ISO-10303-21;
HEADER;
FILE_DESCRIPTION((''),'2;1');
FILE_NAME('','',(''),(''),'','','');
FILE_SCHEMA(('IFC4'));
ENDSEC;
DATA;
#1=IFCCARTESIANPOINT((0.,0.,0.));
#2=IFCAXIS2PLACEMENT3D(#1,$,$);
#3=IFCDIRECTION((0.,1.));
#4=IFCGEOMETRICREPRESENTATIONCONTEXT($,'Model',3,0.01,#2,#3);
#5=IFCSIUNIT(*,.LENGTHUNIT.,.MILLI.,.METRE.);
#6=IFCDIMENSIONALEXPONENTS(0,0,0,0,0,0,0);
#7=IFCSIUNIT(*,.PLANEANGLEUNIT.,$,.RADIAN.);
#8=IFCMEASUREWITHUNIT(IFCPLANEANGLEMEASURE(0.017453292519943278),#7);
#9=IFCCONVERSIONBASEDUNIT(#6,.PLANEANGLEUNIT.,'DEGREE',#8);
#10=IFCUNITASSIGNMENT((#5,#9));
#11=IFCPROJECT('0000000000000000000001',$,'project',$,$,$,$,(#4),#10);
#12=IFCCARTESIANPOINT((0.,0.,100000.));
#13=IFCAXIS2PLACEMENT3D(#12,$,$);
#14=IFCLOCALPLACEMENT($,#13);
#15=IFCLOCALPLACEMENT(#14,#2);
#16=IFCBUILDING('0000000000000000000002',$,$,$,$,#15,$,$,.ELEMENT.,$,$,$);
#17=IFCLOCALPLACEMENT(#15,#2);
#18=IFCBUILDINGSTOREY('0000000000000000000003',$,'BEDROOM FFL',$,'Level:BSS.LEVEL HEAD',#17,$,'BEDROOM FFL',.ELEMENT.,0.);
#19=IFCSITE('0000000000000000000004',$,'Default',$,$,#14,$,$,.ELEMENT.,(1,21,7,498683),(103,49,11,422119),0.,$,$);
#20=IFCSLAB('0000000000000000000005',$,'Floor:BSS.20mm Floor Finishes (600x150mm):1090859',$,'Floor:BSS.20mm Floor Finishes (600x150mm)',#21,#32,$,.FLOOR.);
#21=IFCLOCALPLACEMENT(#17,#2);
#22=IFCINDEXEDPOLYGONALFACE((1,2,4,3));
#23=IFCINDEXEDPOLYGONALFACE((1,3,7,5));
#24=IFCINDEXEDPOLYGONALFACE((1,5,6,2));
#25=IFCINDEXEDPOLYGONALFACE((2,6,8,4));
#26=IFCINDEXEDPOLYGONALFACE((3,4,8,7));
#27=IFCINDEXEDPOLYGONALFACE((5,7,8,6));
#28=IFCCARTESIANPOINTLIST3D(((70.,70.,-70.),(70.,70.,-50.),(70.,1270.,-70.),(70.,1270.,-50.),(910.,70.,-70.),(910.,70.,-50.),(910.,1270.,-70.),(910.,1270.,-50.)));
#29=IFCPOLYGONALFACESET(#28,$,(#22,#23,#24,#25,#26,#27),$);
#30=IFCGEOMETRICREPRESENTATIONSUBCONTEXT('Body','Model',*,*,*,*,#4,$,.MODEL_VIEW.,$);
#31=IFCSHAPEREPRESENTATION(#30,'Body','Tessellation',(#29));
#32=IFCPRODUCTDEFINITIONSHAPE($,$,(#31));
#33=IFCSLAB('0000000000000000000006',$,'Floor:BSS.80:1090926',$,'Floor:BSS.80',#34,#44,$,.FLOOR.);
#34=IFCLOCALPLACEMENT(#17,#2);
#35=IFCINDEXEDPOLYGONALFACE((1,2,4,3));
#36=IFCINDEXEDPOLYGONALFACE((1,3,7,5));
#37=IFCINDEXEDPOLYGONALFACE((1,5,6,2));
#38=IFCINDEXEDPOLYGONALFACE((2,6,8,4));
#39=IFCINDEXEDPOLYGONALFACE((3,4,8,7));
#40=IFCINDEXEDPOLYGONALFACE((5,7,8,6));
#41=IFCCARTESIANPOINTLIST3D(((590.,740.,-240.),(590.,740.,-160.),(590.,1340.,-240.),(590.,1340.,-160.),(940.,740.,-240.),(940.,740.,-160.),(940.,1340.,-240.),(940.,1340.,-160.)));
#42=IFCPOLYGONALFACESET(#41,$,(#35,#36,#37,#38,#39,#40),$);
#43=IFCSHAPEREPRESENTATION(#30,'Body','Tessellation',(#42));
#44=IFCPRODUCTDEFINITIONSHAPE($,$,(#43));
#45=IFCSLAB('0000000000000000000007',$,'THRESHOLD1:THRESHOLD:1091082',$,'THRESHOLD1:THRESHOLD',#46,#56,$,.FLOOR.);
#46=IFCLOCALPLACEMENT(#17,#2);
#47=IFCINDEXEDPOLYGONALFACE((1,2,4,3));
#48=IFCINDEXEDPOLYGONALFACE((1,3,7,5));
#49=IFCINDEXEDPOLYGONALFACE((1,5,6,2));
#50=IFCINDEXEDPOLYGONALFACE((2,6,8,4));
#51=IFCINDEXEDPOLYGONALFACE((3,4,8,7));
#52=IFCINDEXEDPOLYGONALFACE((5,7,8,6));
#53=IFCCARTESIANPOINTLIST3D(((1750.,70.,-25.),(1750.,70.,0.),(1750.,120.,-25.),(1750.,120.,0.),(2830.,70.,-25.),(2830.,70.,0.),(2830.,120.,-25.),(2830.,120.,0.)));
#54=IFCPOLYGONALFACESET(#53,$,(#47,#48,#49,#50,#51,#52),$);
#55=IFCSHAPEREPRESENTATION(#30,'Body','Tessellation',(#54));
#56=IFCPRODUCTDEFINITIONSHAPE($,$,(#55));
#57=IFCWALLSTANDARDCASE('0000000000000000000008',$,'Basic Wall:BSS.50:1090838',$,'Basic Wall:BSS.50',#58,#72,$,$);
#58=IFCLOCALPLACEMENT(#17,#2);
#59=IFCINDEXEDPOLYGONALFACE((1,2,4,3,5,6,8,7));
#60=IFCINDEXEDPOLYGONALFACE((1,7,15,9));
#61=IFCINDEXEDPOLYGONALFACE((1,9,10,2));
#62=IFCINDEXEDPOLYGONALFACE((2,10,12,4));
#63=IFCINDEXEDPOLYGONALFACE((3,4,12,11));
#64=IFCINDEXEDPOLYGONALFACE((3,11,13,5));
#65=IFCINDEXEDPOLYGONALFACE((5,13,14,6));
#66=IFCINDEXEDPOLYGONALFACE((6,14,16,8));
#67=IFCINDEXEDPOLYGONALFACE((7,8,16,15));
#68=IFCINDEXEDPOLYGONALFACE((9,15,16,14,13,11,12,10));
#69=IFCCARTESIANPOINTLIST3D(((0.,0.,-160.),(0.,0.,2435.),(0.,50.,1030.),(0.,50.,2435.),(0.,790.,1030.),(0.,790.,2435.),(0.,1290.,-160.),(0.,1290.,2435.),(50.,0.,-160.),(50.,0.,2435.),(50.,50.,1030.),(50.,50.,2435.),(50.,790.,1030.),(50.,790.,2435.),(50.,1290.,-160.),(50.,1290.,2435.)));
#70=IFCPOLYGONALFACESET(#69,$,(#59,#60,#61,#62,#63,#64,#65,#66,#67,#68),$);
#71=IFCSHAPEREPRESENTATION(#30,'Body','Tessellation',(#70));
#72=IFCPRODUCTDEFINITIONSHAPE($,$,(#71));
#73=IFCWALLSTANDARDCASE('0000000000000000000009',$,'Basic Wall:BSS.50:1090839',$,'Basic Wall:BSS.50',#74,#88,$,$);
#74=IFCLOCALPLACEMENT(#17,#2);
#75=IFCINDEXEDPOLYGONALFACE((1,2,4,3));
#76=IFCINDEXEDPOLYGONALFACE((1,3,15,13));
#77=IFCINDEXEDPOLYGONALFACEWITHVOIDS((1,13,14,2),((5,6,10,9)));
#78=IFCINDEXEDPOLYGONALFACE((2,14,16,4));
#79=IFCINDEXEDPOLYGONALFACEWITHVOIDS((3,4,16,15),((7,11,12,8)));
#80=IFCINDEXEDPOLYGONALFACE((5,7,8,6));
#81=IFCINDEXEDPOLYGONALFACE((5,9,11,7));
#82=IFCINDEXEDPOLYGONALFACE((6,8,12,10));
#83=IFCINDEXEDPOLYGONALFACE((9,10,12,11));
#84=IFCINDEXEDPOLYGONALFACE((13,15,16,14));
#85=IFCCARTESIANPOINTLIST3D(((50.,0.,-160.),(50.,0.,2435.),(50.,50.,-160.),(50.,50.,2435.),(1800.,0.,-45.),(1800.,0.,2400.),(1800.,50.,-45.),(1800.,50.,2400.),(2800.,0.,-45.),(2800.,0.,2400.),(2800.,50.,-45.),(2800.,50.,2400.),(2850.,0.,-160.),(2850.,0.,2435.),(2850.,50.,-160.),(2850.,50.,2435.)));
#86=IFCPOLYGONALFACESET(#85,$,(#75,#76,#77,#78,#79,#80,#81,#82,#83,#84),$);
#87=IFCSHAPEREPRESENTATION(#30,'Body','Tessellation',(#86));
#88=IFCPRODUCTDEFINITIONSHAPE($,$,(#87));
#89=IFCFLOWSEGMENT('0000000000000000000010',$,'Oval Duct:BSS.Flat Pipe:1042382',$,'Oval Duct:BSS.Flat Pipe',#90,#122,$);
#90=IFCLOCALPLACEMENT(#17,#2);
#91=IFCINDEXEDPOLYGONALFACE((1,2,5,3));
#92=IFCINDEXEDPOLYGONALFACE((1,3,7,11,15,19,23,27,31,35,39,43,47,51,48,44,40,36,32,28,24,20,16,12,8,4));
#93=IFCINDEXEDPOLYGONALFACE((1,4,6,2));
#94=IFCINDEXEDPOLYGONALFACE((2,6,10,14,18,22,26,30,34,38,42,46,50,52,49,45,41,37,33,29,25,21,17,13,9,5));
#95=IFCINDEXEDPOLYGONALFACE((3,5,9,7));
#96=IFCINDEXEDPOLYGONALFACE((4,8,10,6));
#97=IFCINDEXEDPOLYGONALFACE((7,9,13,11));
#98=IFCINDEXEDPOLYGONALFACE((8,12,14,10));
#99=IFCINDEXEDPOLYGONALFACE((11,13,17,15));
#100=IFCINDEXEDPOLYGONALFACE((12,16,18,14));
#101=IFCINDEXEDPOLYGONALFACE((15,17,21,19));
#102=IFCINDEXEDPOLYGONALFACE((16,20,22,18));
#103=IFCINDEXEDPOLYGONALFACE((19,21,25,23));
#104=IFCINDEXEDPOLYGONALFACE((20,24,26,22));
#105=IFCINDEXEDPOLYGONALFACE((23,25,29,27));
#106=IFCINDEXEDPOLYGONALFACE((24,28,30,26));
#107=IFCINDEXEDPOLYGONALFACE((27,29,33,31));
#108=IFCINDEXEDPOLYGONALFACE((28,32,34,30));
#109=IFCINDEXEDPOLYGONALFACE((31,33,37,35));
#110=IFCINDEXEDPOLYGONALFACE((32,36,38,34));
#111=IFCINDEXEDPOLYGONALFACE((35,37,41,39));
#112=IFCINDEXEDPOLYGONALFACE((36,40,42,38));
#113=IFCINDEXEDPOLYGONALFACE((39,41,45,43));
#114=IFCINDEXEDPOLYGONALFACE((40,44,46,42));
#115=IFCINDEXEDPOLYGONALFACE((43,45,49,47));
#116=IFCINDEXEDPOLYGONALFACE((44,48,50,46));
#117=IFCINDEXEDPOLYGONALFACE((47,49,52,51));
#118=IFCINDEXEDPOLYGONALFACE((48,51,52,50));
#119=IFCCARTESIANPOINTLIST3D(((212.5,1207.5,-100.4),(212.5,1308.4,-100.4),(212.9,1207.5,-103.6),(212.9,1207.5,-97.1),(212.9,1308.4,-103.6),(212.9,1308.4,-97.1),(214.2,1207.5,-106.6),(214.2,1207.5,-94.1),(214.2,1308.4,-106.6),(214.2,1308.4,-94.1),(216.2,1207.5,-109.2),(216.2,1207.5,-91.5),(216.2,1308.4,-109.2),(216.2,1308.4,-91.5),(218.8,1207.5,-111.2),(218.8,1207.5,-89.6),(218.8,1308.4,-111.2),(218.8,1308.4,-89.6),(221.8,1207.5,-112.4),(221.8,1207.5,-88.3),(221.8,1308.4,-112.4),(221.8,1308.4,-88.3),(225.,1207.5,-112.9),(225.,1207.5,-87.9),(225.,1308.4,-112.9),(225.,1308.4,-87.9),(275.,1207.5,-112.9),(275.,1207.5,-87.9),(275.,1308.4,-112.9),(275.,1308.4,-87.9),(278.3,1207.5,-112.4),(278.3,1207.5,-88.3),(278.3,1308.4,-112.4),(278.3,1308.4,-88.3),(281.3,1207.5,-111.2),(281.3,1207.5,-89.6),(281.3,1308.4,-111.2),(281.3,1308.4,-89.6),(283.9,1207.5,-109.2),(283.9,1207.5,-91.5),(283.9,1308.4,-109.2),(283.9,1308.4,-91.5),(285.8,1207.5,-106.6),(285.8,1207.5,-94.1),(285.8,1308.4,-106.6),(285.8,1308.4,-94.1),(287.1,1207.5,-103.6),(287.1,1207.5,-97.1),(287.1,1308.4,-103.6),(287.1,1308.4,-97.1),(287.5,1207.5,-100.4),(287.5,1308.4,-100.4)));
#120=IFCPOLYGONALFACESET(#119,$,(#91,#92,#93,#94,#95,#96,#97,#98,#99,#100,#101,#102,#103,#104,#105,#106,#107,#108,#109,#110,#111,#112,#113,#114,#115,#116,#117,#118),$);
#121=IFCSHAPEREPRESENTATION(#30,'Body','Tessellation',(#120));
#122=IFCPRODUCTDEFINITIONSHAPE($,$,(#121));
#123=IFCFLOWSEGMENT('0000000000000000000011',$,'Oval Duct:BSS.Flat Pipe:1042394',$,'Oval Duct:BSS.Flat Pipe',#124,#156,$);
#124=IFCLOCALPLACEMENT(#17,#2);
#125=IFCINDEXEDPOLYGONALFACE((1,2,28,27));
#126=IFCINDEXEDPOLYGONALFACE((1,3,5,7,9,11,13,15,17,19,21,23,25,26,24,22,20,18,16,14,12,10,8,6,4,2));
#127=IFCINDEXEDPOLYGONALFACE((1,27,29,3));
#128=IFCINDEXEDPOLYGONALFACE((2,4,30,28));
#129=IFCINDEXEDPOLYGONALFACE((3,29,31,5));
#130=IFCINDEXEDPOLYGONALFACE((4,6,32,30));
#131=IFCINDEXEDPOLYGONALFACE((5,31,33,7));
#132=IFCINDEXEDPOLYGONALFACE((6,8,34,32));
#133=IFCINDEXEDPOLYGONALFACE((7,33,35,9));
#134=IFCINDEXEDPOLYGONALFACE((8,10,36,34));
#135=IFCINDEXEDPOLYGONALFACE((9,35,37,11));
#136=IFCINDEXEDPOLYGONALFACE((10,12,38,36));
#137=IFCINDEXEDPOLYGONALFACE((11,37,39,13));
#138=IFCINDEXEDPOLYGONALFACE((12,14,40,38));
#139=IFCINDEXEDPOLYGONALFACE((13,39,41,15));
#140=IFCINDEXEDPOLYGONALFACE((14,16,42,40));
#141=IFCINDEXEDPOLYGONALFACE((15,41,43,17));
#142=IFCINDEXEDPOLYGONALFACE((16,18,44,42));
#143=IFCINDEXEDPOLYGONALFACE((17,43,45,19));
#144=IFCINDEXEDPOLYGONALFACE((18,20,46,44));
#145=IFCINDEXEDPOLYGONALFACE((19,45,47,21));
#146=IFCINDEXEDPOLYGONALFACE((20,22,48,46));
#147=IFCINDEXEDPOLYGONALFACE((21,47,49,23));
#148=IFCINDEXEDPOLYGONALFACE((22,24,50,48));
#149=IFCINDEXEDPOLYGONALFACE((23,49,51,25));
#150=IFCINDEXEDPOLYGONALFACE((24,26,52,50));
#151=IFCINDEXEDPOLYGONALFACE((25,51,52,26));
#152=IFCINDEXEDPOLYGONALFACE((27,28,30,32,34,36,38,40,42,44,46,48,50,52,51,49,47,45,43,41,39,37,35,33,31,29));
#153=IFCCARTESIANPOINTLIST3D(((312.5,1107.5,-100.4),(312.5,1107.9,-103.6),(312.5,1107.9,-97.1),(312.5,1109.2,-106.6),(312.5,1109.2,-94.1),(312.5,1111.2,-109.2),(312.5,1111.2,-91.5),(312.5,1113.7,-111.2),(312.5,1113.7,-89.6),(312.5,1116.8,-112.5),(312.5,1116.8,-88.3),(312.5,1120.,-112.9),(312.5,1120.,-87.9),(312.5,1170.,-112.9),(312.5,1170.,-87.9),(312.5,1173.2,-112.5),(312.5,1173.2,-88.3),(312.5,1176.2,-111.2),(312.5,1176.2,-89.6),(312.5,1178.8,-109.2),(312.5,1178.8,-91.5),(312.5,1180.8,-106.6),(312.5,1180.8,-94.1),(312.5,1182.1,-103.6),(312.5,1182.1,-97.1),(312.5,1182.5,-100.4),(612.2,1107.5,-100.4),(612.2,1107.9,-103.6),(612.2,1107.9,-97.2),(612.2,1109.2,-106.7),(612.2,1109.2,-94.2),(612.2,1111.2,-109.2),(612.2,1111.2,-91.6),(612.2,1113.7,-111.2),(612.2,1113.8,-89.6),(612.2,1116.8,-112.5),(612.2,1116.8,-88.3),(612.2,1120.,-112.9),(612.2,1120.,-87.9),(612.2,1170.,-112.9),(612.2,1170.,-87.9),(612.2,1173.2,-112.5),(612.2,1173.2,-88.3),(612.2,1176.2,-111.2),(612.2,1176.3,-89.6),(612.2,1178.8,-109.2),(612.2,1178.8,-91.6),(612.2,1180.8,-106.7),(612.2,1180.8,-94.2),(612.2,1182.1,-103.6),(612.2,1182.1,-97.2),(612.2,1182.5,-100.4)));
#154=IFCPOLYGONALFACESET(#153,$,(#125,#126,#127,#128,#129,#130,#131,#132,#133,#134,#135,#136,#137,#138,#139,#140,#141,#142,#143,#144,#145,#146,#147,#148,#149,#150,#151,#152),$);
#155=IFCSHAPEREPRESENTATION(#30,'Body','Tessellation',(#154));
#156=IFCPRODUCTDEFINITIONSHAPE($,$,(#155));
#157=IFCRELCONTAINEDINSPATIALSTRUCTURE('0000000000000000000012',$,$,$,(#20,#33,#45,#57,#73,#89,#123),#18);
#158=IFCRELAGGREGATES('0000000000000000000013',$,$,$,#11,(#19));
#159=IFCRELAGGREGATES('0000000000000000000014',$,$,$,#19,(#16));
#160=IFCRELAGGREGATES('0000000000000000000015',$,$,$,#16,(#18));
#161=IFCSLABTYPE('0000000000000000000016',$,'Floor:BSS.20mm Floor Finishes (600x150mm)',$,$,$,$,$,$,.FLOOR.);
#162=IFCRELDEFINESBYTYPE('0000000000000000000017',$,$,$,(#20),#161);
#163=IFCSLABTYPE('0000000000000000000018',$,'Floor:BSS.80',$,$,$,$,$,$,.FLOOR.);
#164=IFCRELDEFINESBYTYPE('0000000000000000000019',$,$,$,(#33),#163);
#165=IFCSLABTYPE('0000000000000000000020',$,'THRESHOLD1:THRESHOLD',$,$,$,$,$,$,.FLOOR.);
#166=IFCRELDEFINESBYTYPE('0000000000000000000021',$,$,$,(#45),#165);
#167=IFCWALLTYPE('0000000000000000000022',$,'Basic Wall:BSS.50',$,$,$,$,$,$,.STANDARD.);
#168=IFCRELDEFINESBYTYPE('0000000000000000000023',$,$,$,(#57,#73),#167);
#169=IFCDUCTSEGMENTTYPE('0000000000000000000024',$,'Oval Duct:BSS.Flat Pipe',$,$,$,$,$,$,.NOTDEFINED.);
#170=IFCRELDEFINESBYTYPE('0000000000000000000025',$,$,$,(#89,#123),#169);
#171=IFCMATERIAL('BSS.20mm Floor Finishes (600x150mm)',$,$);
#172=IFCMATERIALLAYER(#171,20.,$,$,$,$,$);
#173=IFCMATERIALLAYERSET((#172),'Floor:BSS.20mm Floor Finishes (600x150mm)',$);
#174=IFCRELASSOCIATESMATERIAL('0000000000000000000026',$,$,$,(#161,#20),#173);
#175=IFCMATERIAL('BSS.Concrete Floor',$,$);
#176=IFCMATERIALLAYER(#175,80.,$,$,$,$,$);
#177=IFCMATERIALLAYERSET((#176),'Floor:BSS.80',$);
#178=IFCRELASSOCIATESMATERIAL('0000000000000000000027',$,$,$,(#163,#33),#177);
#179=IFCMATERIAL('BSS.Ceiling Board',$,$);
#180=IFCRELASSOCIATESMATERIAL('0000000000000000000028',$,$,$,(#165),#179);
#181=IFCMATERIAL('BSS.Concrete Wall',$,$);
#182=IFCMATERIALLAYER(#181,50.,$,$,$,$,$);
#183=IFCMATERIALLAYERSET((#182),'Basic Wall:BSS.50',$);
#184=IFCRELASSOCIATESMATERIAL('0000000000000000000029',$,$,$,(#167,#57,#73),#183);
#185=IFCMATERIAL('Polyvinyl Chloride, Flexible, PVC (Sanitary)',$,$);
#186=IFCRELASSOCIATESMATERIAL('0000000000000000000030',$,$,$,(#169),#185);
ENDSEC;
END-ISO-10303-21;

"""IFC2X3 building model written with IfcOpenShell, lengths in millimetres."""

from ifc_helpers import new_model, entity, si_unit, converted_unit, direction, frame, frame_2d, origin, origin_2d_with_axis, place, context, subcontext, project, spatial, polyline, circle_curve, parameter, trimmed, segment, composite_curve, rectangle, outline, extrude, material, layer, layer_set, layer_usage, type_object, element, save


model = new_model("IFC2X3")

# Units and contexts
model_context = context("Model", 3, precision=0.01, world=origin(), true_north=direction((0.0, 1.0)))
body_context = subcontext(model_context, "Body", "Model", "MODEL_VIEW")
ifc_project = project(units=[si_unit("LENGTHUNIT", "METRE", prefix="MILLI"), converted_unit("PLANEANGLEUNIT", "DEGREE", entity("IfcPlaneAngleMeasure", 0.017453292519943278), si_unit("PLANEANGLEUNIT", "RADIAN"), dimensions=[0, 0, 0, 0, 0, 0, 0])], contexts=[model_context])

# Site, building, storey
site_placement = place(None, frame((0.0, 0.0, 100000.0)))
site = spatial("IfcSite", under=ifc_project, at=site_placement, Name="Default", CompositionType="ELEMENT", RefLatitude=(1, 21, 7, 498683), RefLongitude=(103, 49, 11, 422119), RefElevation=0.0)
building_placement = place(site_placement, origin())
building = spatial("IfcBuilding", under=site, at=building_placement, CompositionType="ELEMENT")
storey_placement = place(building_placement, origin())
storey = spatial("IfcBuildingStorey", under=building, at=storey_placement, Name="BEDROOM FFL", ObjectType="Level:BSS.LEVEL HEAD", LongName="BEDROOM FFL", CompositionType="ELEMENT", Elevation=0.0)

# Slabs
ifc_material_1 = material(Name="BSS.Concrete Floor")
ifc_material_2 = material(Name="BSS.20mm Floor Finishes (600x150mm)")
ifc_layer_1 = layer(ifc_material_2, 20.0)
ifc_layer_set_1 = layer_set([ifc_layer_1], Name="Floor:BSS.20mm Floor Finishes (600x150mm)")
ifc_layer_usage_1 = layer_usage(ifc_layer_set_1, "AXIS3", "POSITIVE", 0.0)
slab_type_1 = type_object("IfcSlabType", Name="Floor:BSS.20mm Floor Finishes (600x150mm)", PredefinedType="FLOOR", material=ifc_layer_set_1)
slab_1_placement = place(storey_placement, origin())
element("IfcSlab", 1, at=slab_1_placement, inside=storey, type_object=slab_type_1, material=ifc_layer_usage_1, Name="Floor:BSS.20mm Floor Finishes (600x150mm):1090859", ObjectType="Floor:BSS.20mm Floor Finishes (600x150mm)", PredefinedType="FLOOR", context=body_context, shape_type="SweptSolid", body=[
    extrude(rectangle(XDim=1200.0, YDim=840.0, at=frame_2d((0.0, 0.0), x_axis=(1.0, 0.0))), frame((490.0, 670.0, -50.0), z_axis=(0.0, 0.0, -1.0), x_axis=(0.0, 1.0, 0.0)), (0.0, 0.0, 1.0), 20.0),
])
ifc_layer_2 = layer(ifc_material_1, 80.0)
ifc_layer_set_2 = layer_set([ifc_layer_2], Name="Floor:BSS.80")
ifc_layer_usage_2 = layer_usage(ifc_layer_set_2, "AXIS3", "POSITIVE", 0.0)
slab_type_2 = type_object("IfcSlabType", Name="Floor:BSS.80", PredefinedType="FLOOR", material=ifc_layer_set_2)
slab_2_placement = place(storey_placement, origin())
element("IfcSlab", 2, at=slab_2_placement, inside=storey, type_object=slab_type_2, material=ifc_layer_usage_2, Name="Floor:BSS.80:1090926", ObjectType="Floor:BSS.80", PredefinedType="FLOOR", context=body_context, shape_type="SweptSolid", body=[
    extrude(rectangle(XDim=600.0, YDim=350.0, at=frame_2d((0.0, 0.0), x_axis=(1.0, 0.0))), frame((765.0, 1040.0, -160.0), z_axis=(0.0, 0.0, -1.0), x_axis=(0.0, 1.0, 0.0)), (0.0, 0.0, 1.0), 80.0),
])
ifc_material_3 = material(Name="BSS.Ceiling Board")
slab_type_3 = type_object("IfcSlabType", Name="THRESHOLD1:THRESHOLD", PredefinedType="FLOOR", material=ifc_material_3)
slab_3_placement = place(storey_placement, origin())
element("IfcSlab", 3, at=slab_3_placement, inside=storey, type_object=slab_type_3, Name="THRESHOLD1:THRESHOLD:1091082", ObjectType="THRESHOLD1:THRESHOLD", PredefinedType="FLOOR", context=body_context, shape_type="SweptSolid", body=[
    extrude(rectangle(XDim=1080.0, YDim=50.0, at=frame_2d((0.0, 0.0), x_axis=(1.0, 0.0))), frame((2290.0, 95.0, -25.0)), (0.0, 0.0, 1.0), 25.0),
])

# Walls, openings
ifc_material_4 = material(Name="BSS.Concrete Wall")
ifc_layer_3 = layer(ifc_material_4, 50.0)
ifc_layer_set_3 = layer_set([ifc_layer_3], Name="Basic Wall:BSS.50")
ifc_layer_usage_3 = layer_usage(ifc_layer_set_3, "AXIS2", "NEGATIVE", 25.0)
wall_type = type_object("IfcWallType", Name="Basic Wall:BSS.50", PredefinedType="STANDARD", material=ifc_layer_set_3)
wall_1_placement = place(storey_placement, frame((25.0, 1290.0, -160.0), z_axis=(0.0, 0.0, 1.0), x_axis=(0.0, -1.0, 0.0)))
wall_1 = element("IfcWallStandardCase", 4, at=wall_1_placement, inside=storey, type_object=wall_type, material=ifc_layer_usage_3, Name="Basic Wall:BSS.50:1090838", ObjectType="Basic Wall:BSS.50", context=body_context, shape_type="SweptSolid", body=[
    extrude(rectangle(XDim=1290.0, YDim=50.0, at=frame_2d((645.0, 0.0), x_axis=(-1.0, 0.0))), origin(), (0.0, 0.0, 1.0), 2595.0),
])
opening_1_placement = place(wall_1_placement, frame((1290.0, -25.0, 160.0), z_axis=(0.0, 0.0, 1.0), x_axis=(0.0, 1.0, 0.0)))
element("IfcOpeningElement", 5, at=opening_1_placement, cuts=wall_1, ObjectType="Opening", context=body_context, shape_type="SweptSolid", body=[
    extrude(rectangle(XDim=1405.0, YDim=740.0, at=origin_2d_with_axis()), frame((-1474.0, 420.0, 1732.5), z_axis=(1.0, 0.0, 0.0), x_axis=(0.0, 0.0, -1.0)), (0.0, 0.0, 1.0), 3048.0),
])
ifc_layer_usage_4 = layer_usage(ifc_layer_set_3, "AXIS2", "POSITIVE", -25.0)
wall_2_placement = place(storey_placement, frame((50.0, 25.0, -160.0)))
wall_2 = element("IfcWallStandardCase", 6, at=wall_2_placement, inside=storey, type_object=wall_type, material=ifc_layer_usage_4, Name="Basic Wall:BSS.50:1090839", ObjectType="Basic Wall:BSS.50", context=body_context, shape_type="SweptSolid", body=[
    extrude(rectangle(XDim=2800.0, YDim=50.0, at=frame_2d((1400.0, 0.0), x_axis=(-1.0, 0.0))), origin(), (0.0, 0.0, 1.0), 2595.0),
])
opening_2_placement = place(wall_2_placement, frame((-50.0, -25.0, 160.0)))
element("IfcOpeningElement", 7, at=opening_2_placement, cuts=wall_2, ObjectType="Opening", context=body_context, shape_type="SweptSolid", body=[
    extrude(rectangle(XDim=2445.0, YDim=1000.0, at=frame_2d((0.0, 0.0), x_axis=(1.0, 0.0))), frame((2300.0, -1474.0, 1177.5), z_axis=(0.0, 1.0, 0.0), x_axis=(0.0, 0.0, -1.0)), (0.0, 0.0, 1.0), 3048.0),
])

# Flow segments
ifc_material_5 = material(Name="Polyvinyl Chloride, Flexible, PVC (Sanitary)")
duct_segment_type = type_object("IfcDuctSegmentType", Name="Oval Duct:BSS.Flat Pipe", PredefinedType="NOTDEFINED", material=ifc_material_5)
flow_segment_1_placement = place(storey_placement, origin())
element("IfcFlowSegment", 8, at=flow_segment_1_placement, inside=storey, type_object=duct_segment_type, Name="Oval Duct:BSS.Flat Pipe:1042382", ObjectType="Oval Duct:BSS.Flat Pipe", context=body_context, shape_type="SweptSolid", body=[
    extrude(outline(composite_curve([segment(polyline([(-25.0, -12.5), (25.0, -12.5)]), True, "CONTINUOUS"), segment(trimmed(circle_curve(frame_2d((25.0, 0.0), x_axis=(-1.0, 0.0)), 12.5), [parameter(90.0)], [parameter(180.0)], True, "PARAMETER"), True, "CONTINUOUS"), segment(trimmed(circle_curve(frame_2d((25.0, 0.0), x_axis=(-1.0, 0.0)), 12.5), [parameter(180.0)], [parameter(270.0)], True, "PARAMETER"), True, "CONTINUOUS"), segment(polyline([(25.0, 12.5), (-25.0, 12.5)]), True, "CONTINUOUS"), segment(trimmed(circle_curve(frame_2d((-25.0, 0.0), x_axis=(-1.0, 0.0)), 12.5), [parameter(270.0)], [parameter(0.0)], True, "PARAMETER"), True, "CONTINUOUS"), segment(trimmed(circle_curve(frame_2d((-25.0, 0.0), x_axis=(-1.0, 0.0)), 12.5), [parameter(0.0)], [parameter(90.0)], True, "PARAMETER"), True, "CONTINUOUS")], self_intersect=False)), frame((250.0, 1207.5, -100.4), z_axis=(0.0, 1.0, 0.0), x_axis=(1.0, 0.0, 0.0)), (0.0, 0.0, 1.0), 100.9),
])
flow_segment_2_placement = place(storey_placement, origin())
element("IfcFlowSegment", 9, at=flow_segment_2_placement, inside=storey, type_object=duct_segment_type, Name="Oval Duct:BSS.Flat Pipe:1042394", ObjectType="Oval Duct:BSS.Flat Pipe", context=body_context, shape_type="SweptSolid", body=[
    extrude(outline(composite_curve([segment(polyline([(-25.0, -12.5), (25.0, -12.5)]), True, "CONTINUOUS"), segment(trimmed(circle_curve(frame_2d((25.0, 0.0), x_axis=(-1.0, 0.0)), 12.5), [parameter(90.0)], [parameter(180.0)], True, "PARAMETER"), True, "CONTINUOUS"), segment(trimmed(circle_curve(frame_2d((25.0, 0.0), x_axis=(-1.0, 0.0)), 12.5), [parameter(180.0)], [parameter(270.0)], True, "PARAMETER"), True, "CONTINUOUS"), segment(polyline([(25.0, 12.5), (-25.0, 12.5)]), True, "CONTINUOUS"), segment(trimmed(circle_curve(frame_2d((-25.0, 0.0), x_axis=(-1.0, 0.0)), 12.5), [parameter(270.0)], [parameter(0.0)], True, "PARAMETER"), True, "CONTINUOUS"), segment(trimmed(circle_curve(frame_2d((-25.0, 0.0), x_axis=(-1.0, 0.0)), 12.5), [parameter(0.0)], [parameter(90.0)], True, "PARAMETER"), True, "CONTINUOUS")], self_intersect=False)), frame((312.5, 1145.0, -100.4), z_axis=(1.0, 0.000002, -0.000075), x_axis=(0.000002, -1.0, 0.0)), (0.0, 0.0, 1.0), 299.7),
])

save(model, "model.ifc")
